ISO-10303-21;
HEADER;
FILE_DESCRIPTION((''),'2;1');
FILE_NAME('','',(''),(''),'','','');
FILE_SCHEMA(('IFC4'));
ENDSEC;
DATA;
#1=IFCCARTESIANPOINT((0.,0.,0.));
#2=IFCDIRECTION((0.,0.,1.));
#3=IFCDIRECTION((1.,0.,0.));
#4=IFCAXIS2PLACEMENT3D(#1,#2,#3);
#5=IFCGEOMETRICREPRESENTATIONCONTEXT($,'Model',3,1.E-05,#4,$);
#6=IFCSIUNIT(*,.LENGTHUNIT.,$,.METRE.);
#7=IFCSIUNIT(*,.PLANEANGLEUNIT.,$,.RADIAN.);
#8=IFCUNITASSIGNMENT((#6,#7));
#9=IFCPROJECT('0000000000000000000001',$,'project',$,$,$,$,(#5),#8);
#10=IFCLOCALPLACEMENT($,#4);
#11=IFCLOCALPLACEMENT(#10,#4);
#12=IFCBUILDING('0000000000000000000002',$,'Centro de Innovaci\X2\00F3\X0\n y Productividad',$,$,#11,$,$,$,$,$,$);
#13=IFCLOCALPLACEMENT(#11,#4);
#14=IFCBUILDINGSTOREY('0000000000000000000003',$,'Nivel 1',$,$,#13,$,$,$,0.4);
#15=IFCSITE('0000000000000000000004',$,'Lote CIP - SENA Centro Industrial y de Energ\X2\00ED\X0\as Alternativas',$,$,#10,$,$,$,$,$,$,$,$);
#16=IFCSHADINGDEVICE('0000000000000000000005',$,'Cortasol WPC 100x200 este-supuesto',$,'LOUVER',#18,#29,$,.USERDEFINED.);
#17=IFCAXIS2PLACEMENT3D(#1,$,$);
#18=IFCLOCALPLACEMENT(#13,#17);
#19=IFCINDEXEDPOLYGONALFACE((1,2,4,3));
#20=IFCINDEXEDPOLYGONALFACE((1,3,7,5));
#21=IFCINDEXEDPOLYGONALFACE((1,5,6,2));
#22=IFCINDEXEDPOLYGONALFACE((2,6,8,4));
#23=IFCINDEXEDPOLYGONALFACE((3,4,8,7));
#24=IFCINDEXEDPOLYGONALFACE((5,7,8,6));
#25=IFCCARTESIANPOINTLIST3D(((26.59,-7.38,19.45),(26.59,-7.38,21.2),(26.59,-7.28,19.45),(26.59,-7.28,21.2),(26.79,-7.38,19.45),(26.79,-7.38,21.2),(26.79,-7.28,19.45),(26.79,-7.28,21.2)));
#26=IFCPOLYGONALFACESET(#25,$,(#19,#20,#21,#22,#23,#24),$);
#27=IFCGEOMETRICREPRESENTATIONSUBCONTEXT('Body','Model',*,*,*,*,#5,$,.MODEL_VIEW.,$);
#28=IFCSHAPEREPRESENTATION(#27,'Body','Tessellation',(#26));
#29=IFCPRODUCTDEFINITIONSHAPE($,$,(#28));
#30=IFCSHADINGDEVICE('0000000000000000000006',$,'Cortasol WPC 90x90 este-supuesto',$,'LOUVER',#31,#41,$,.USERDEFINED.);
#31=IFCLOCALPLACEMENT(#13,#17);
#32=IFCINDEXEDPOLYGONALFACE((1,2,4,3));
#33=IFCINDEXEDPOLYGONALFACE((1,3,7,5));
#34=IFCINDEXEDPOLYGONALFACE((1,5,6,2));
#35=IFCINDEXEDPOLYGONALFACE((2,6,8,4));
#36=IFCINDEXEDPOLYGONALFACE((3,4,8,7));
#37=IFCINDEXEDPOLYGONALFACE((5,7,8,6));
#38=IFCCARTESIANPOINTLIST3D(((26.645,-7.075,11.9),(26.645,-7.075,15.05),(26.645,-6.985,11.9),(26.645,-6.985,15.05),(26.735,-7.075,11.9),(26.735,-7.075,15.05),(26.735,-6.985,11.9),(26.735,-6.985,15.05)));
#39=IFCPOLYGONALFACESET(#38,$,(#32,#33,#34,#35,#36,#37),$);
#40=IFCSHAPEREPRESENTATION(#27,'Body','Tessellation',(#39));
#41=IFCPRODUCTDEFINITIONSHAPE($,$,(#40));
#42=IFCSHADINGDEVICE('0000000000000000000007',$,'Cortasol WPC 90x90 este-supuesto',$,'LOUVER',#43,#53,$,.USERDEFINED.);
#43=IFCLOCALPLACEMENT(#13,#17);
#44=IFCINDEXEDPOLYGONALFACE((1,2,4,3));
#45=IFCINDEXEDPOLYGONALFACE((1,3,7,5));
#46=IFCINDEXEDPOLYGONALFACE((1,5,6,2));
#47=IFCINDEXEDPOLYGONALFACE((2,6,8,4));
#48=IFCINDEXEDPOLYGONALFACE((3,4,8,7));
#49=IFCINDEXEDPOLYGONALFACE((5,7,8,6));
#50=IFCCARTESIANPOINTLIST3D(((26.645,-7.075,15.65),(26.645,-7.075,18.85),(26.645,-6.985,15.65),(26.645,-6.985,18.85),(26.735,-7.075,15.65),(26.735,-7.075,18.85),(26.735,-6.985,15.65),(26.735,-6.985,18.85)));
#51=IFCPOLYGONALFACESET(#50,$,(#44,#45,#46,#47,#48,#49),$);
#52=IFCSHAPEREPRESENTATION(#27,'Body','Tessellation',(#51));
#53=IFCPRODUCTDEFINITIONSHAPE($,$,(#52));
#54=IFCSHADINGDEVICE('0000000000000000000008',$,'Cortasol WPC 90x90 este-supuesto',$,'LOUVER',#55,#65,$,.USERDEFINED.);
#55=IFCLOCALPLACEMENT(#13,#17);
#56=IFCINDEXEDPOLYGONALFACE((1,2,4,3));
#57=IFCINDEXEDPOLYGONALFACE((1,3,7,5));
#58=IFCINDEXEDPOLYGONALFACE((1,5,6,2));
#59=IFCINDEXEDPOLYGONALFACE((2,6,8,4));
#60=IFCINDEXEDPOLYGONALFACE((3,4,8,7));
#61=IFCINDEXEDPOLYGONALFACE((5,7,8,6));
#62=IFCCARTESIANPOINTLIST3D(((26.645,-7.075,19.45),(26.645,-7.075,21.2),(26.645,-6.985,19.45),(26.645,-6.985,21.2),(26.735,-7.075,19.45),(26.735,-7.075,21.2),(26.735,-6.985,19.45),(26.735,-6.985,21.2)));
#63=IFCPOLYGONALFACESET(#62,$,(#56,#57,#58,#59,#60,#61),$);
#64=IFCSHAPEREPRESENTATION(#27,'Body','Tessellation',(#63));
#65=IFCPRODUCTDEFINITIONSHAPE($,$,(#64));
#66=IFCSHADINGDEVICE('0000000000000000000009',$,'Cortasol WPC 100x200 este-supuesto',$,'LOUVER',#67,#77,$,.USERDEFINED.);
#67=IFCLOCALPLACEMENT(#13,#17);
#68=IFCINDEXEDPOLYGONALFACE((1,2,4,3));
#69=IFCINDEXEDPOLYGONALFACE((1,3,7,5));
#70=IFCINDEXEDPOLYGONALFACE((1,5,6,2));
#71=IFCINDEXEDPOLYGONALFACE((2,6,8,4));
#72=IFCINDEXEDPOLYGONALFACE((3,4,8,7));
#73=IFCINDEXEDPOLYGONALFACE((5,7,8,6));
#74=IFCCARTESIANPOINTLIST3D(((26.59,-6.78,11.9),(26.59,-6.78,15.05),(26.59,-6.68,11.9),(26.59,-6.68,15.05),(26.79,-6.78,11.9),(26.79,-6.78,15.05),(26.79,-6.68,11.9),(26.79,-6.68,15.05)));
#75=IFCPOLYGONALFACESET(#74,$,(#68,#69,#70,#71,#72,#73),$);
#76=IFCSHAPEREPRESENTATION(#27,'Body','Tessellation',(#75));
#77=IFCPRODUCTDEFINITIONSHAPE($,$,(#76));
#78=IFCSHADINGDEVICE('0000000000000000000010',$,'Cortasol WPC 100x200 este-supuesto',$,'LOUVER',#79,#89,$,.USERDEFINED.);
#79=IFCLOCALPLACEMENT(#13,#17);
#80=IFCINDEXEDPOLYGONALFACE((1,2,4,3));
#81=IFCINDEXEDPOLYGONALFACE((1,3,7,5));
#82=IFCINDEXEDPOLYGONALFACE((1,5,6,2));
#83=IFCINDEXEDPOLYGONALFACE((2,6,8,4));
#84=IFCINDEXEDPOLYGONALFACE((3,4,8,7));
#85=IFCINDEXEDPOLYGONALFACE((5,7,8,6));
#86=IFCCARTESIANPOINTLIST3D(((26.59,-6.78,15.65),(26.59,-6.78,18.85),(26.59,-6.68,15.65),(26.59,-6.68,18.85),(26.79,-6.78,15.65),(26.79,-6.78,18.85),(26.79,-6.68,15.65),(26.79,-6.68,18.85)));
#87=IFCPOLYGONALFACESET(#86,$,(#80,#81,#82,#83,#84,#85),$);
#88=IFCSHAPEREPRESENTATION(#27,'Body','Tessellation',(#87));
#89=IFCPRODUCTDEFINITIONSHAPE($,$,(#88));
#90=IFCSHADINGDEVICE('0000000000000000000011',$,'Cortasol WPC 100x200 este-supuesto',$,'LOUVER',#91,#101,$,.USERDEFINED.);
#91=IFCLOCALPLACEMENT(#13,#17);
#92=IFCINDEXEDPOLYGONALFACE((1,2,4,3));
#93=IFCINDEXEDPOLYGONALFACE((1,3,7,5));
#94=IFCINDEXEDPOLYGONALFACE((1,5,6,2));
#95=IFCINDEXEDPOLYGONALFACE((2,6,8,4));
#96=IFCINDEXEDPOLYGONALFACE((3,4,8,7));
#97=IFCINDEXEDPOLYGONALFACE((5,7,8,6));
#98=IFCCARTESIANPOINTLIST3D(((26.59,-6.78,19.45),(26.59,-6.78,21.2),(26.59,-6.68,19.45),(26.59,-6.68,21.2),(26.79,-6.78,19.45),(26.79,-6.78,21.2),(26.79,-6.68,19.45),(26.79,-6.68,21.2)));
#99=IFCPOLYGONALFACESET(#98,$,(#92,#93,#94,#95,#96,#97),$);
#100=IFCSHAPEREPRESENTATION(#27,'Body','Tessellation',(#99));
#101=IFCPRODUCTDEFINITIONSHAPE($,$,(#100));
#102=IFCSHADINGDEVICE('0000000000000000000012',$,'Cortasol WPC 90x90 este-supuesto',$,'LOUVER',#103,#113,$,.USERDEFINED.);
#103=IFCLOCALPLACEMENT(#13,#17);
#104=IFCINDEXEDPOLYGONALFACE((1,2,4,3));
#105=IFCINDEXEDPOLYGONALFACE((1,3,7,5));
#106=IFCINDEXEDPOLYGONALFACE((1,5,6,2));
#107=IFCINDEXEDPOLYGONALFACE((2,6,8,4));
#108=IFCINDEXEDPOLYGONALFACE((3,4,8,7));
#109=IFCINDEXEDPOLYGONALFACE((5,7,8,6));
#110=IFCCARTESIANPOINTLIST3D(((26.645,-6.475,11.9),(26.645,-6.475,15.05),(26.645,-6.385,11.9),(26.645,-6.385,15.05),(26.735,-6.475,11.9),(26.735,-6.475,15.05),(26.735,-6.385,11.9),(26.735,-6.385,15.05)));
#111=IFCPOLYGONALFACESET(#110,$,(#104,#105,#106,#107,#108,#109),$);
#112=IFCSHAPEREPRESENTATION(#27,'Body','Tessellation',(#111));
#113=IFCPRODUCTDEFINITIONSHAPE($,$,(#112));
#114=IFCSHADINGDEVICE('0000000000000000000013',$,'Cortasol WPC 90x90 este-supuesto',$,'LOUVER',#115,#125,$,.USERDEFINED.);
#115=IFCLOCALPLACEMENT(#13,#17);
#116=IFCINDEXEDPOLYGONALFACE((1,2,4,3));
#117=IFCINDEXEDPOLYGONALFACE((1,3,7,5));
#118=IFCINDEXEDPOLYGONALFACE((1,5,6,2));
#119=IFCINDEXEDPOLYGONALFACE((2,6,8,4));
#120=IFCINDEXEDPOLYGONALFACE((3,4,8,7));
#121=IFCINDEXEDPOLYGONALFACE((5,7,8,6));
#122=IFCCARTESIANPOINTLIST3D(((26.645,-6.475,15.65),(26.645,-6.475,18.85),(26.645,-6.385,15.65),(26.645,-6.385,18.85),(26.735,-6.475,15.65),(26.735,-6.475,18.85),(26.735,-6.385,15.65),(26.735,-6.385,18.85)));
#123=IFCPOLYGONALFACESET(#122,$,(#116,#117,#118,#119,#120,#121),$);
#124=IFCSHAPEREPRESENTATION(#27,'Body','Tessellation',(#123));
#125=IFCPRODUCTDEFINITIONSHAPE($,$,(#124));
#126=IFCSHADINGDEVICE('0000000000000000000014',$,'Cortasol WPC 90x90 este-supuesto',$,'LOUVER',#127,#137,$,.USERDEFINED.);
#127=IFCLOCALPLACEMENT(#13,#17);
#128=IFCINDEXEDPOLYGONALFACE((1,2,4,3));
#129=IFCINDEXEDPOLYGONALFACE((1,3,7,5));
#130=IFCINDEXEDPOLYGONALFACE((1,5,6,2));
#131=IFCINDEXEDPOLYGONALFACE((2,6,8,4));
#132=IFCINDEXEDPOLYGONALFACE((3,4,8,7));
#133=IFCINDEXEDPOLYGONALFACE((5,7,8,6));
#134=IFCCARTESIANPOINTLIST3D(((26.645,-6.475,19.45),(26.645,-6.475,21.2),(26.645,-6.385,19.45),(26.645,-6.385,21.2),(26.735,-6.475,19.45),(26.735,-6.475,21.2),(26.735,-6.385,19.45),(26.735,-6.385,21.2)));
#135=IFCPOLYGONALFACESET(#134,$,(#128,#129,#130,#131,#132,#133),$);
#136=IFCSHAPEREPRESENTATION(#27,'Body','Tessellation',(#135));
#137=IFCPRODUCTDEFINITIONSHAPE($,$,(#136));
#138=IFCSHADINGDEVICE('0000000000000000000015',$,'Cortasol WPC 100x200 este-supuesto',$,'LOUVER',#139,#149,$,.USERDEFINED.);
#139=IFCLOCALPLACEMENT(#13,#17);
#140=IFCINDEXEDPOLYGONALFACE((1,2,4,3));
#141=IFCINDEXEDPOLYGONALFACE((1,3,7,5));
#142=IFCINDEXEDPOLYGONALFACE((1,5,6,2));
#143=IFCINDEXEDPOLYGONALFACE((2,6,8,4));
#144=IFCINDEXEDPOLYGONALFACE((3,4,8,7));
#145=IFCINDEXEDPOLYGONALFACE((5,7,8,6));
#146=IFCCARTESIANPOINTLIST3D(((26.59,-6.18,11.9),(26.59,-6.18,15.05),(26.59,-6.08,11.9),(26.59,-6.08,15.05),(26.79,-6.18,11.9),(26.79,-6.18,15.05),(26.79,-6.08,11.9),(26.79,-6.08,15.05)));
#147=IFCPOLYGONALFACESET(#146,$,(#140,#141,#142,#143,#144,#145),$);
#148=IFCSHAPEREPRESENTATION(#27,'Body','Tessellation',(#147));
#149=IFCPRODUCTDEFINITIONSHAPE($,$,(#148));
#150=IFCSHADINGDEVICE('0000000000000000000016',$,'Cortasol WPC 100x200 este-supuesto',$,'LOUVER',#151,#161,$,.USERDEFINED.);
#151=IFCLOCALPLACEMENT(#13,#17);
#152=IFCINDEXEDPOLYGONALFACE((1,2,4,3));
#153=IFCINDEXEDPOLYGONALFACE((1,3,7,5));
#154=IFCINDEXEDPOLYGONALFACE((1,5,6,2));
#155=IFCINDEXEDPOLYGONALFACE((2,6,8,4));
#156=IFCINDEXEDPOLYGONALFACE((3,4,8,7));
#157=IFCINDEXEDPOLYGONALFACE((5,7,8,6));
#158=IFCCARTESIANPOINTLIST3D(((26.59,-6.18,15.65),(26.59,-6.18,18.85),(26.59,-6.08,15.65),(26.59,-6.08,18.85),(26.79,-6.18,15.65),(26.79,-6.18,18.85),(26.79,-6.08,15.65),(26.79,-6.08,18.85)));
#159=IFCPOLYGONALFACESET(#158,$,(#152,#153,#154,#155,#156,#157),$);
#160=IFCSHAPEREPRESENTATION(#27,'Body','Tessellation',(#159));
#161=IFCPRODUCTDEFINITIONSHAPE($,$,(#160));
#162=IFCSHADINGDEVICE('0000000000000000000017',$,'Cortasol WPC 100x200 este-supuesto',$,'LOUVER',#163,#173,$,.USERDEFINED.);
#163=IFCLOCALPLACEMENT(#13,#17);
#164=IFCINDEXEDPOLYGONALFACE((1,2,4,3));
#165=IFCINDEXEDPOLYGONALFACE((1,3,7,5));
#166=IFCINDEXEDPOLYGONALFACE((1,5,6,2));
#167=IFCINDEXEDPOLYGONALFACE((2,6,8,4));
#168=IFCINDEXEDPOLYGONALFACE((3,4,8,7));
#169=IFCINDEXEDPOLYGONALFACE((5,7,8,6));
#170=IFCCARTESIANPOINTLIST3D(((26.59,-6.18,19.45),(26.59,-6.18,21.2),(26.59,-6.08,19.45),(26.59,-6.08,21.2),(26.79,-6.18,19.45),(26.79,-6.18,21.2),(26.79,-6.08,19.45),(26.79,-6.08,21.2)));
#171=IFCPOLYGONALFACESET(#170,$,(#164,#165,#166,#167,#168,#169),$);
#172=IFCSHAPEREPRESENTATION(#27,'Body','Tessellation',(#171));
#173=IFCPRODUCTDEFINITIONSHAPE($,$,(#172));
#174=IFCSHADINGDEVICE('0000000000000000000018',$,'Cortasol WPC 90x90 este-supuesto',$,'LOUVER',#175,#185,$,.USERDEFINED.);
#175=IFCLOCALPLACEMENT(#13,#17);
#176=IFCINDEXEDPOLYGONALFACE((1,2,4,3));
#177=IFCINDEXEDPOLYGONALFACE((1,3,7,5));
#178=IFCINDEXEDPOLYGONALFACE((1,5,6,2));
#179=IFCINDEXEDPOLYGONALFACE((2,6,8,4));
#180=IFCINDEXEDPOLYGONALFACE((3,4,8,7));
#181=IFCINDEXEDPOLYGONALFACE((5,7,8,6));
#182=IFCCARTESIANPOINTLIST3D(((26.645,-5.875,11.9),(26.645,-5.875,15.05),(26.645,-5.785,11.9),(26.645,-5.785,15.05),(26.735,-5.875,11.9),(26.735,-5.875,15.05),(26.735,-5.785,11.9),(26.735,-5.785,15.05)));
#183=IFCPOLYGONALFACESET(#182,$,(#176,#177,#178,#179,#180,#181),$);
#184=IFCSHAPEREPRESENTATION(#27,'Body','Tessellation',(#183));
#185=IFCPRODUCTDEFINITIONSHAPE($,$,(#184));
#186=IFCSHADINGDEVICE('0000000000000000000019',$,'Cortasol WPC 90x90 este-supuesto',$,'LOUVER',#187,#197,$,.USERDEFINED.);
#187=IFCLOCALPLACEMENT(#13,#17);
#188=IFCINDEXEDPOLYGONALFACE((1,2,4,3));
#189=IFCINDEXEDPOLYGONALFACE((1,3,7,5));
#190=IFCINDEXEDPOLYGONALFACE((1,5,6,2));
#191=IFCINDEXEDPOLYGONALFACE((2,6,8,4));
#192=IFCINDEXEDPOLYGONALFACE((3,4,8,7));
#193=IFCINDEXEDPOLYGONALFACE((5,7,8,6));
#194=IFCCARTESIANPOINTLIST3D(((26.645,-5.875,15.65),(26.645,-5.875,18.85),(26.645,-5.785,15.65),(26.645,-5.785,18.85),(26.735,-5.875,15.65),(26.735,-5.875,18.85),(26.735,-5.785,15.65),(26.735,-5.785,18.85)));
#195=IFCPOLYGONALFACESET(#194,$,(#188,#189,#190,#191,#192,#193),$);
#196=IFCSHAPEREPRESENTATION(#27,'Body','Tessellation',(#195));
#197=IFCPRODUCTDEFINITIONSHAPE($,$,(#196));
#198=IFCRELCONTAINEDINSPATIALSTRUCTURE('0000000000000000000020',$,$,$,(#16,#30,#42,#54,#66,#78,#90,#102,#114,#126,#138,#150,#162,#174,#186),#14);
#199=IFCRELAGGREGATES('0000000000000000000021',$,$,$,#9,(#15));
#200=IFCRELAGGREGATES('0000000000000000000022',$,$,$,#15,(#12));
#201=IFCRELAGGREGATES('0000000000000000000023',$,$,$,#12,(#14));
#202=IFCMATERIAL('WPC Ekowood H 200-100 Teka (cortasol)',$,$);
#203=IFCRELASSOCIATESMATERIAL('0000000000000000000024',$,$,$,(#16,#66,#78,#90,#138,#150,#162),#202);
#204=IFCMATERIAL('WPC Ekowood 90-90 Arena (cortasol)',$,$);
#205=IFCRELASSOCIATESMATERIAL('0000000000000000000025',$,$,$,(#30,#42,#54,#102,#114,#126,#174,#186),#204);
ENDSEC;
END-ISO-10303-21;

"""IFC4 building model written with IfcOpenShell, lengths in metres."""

from ifc_helpers import new_model, si_unit, frame, origin_with_axes, place, context, subcontext, project, spatial, polyline, outline, extrude, material, element, save


model = new_model("IFC4")

# Units and contexts
model_context = context("Model", 3, precision=1e-05, world=origin_with_axes())
body_context = subcontext(model_context, "Body", "Model", "MODEL_VIEW")
ifc_project = project(units=[si_unit("LENGTHUNIT", "METRE"), si_unit("PLANEANGLEUNIT", "RADIAN")], contexts=[model_context])

# Site, building, storey
site_placement = place(None, origin_with_axes())
site = spatial("IfcSite", under=ifc_project, at=site_placement, Name="Lote CIP - SENA Centro Industrial y de Energías Alternativas")
building_placement = place(site_placement, origin_with_axes())
building = spatial("IfcBuilding", under=site, at=building_placement, Name="Centro de Innovación y Productividad")
storey_placement = place(building_placement, origin_with_axes())
storey = spatial("IfcBuildingStorey", under=building, at=storey_placement, Name="Nivel 1", Elevation=0.4)

# Shading devices
ifc_material_1 = material(Name="WPC Ekowood H 200-100 Teka (cortasol)")
shading_device_1_placement = place(storey_placement, origin_with_axes())
element("IfcShadingDevice", 1, at=shading_device_1_placement, inside=storey, material=ifc_material_1, Name="Cortasol WPC 100x200 este-supuesto", ObjectType="LOUVER", PredefinedType="USERDEFINED", context=body_context, shape_type="SweptSolid", body=[
    extrude(outline(polyline([(26.79, -7.38), (26.59, -7.38), (26.59, -7.28), (26.79, -7.28), (26.79, -7.38)])), frame((0.0, 0.0, 19.45)), (0.0, 0.0, 1.0), 1.75),
])
ifc_material_2 = material(Name="WPC Ekowood 90-90 Arena (cortasol)")
shading_device_2_placement = place(storey_placement, origin_with_axes())
element("IfcShadingDevice", 2, at=shading_device_2_placement, inside=storey, material=ifc_material_2, Name="Cortasol WPC 90x90 este-supuesto", ObjectType="LOUVER", PredefinedType="USERDEFINED", context=body_context, shape_type="SweptSolid", body=[
    extrude(outline(polyline([(26.735, -7.075), (26.645, -7.075), (26.645, -6.985), (26.735, -6.985), (26.735, -7.075)])), frame((0.0, 0.0, 11.9)), (0.0, 0.0, 1.0), 3.15),
])
shading_device_3_placement = place(storey_placement, origin_with_axes())
element("IfcShadingDevice", 3, at=shading_device_3_placement, inside=storey, material=ifc_material_2, Name="Cortasol WPC 90x90 este-supuesto", ObjectType="LOUVER", PredefinedType="USERDEFINED", context=body_context, shape_type="SweptSolid", body=[
    extrude(outline(polyline([(26.735, -7.075), (26.645, -7.075), (26.645, -6.985), (26.735, -6.985), (26.735, -7.075)])), frame((0.0, 0.0, 15.65)), (0.0, 0.0, 1.0), 3.2),
])
shading_device_4_placement = place(storey_placement, origin_with_axes())
element("IfcShadingDevice", 4, at=shading_device_4_placement, inside=storey, material=ifc_material_2, Name="Cortasol WPC 90x90 este-supuesto", ObjectType="LOUVER", PredefinedType="USERDEFINED", context=body_context, shape_type="SweptSolid", body=[
    extrude(outline(polyline([(26.735, -7.075), (26.645, -7.075), (26.645, -6.985), (26.735, -6.985), (26.735, -7.075)])), frame((0.0, 0.0, 19.45)), (0.0, 0.0, 1.0), 1.75),
])
shading_device_5_placement = place(storey_placement, origin_with_axes())
element("IfcShadingDevice", 5, at=shading_device_5_placement, inside=storey, material=ifc_material_1, Name="Cortasol WPC 100x200 este-supuesto", ObjectType="LOUVER", PredefinedType="USERDEFINED", context=body_context, shape_type="SweptSolid", body=[
    extrude(outline(polyline([(26.79, -6.78), (26.59, -6.78), (26.59, -6.68), (26.79, -6.68), (26.79, -6.78)])), frame((0.0, 0.0, 11.9)), (0.0, 0.0, 1.0), 3.15),
])
shading_device_6_placement = place(storey_placement, origin_with_axes())
element("IfcShadingDevice", 6, at=shading_device_6_placement, inside=storey, material=ifc_material_1, Name="Cortasol WPC 100x200 este-supuesto", ObjectType="LOUVER", PredefinedType="USERDEFINED", context=body_context, shape_type="SweptSolid", body=[
    extrude(outline(polyline([(26.79, -6.78), (26.59, -6.78), (26.59, -6.68), (26.79, -6.68), (26.79, -6.78)])), frame((0.0, 0.0, 15.65)), (0.0, 0.0, 1.0), 3.2),
])
shading_device_7_placement = place(storey_placement, origin_with_axes())
element("IfcShadingDevice", 7, at=shading_device_7_placement, inside=storey, material=ifc_material_1, Name="Cortasol WPC 100x200 este-supuesto", ObjectType="LOUVER", PredefinedType="USERDEFINED", context=body_context, shape_type="SweptSolid", body=[
    extrude(outline(polyline([(26.79, -6.78), (26.59, -6.78), (26.59, -6.68), (26.79, -6.68), (26.79, -6.78)])), frame((0.0, 0.0, 19.45)), (0.0, 0.0, 1.0), 1.75),
])
shading_device_8_placement = place(storey_placement, origin_with_axes())
element("IfcShadingDevice", 8, at=shading_device_8_placement, inside=storey, material=ifc_material_2, Name="Cortasol WPC 90x90 este-supuesto", ObjectType="LOUVER", PredefinedType="USERDEFINED", context=body_context, shape_type="SweptSolid", body=[
    extrude(outline(polyline([(26.735, -6.475), (26.645, -6.475), (26.645, -6.385), (26.735, -6.385), (26.735, -6.475)])), frame((0.0, 0.0, 11.9)), (0.0, 0.0, 1.0), 3.15),
])
shading_device_9_placement = place(storey_placement, origin_with_axes())
element("IfcShadingDevice", 9, at=shading_device_9_placement, inside=storey, material=ifc_material_2, Name="Cortasol WPC 90x90 este-supuesto", ObjectType="LOUVER", PredefinedType="USERDEFINED", context=body_context, shape_type="SweptSolid", body=[
    extrude(outline(polyline([(26.735, -6.475), (26.645, -6.475), (26.645, -6.385), (26.735, -6.385), (26.735, -6.475)])), frame((0.0, 0.0, 15.65)), (0.0, 0.0, 1.0), 3.2),
])
shading_device_10_placement = place(storey_placement, origin_with_axes())
element("IfcShadingDevice", 10, at=shading_device_10_placement, inside=storey, material=ifc_material_2, Name="Cortasol WPC 90x90 este-supuesto", ObjectType="LOUVER", PredefinedType="USERDEFINED", context=body_context, shape_type="SweptSolid", body=[
    extrude(outline(polyline([(26.735, -6.475), (26.645, -6.475), (26.645, -6.385), (26.735, -6.385), (26.735, -6.475)])), frame((0.0, 0.0, 19.45)), (0.0, 0.0, 1.0), 1.75),
])
shading_device_11_placement = place(storey_placement, origin_with_axes())
element("IfcShadingDevice", 11, at=shading_device_11_placement, inside=storey, material=ifc_material_1, Name="Cortasol WPC 100x200 este-supuesto", ObjectType="LOUVER", PredefinedType="USERDEFINED", context=body_context, shape_type="SweptSolid", body=[
    extrude(outline(polyline([(26.79, -6.18), (26.59, -6.18), (26.59, -6.08), (26.79, -6.08), (26.79, -6.18)])), frame((0.0, 0.0, 11.9)), (0.0, 0.0, 1.0), 3.15),
])
shading_device_12_placement = place(storey_placement, origin_with_axes())
element("IfcShadingDevice", 12, at=shading_device_12_placement, inside=storey, material=ifc_material_1, Name="Cortasol WPC 100x200 este-supuesto", ObjectType="LOUVER", PredefinedType="USERDEFINED", context=body_context, shape_type="SweptSolid", body=[
    extrude(outline(polyline([(26.79, -6.18), (26.59, -6.18), (26.59, -6.08), (26.79, -6.08), (26.79, -6.18)])), frame((0.0, 0.0, 15.65)), (0.0, 0.0, 1.0), 3.2),
])
shading_device_13_placement = place(storey_placement, origin_with_axes())
element("IfcShadingDevice", 13, at=shading_device_13_placement, inside=storey, material=ifc_material_1, Name="Cortasol WPC 100x200 este-supuesto", ObjectType="LOUVER", PredefinedType="USERDEFINED", context=body_context, shape_type="SweptSolid", body=[
    extrude(outline(polyline([(26.79, -6.18), (26.59, -6.18), (26.59, -6.08), (26.79, -6.08), (26.79, -6.18)])), frame((0.0, 0.0, 19.45)), (0.0, 0.0, 1.0), 1.75),
])
shading_device_14_placement = place(storey_placement, origin_with_axes())
element("IfcShadingDevice", 14, at=shading_device_14_placement, inside=storey, material=ifc_material_2, Name="Cortasol WPC 90x90 este-supuesto", ObjectType="LOUVER", PredefinedType="USERDEFINED", context=body_context, shape_type="SweptSolid", body=[
    extrude(outline(polyline([(26.735, -5.875), (26.645, -5.875), (26.645, -5.785), (26.735, -5.785), (26.735, -5.875)])), frame((0.0, 0.0, 11.9)), (0.0, 0.0, 1.0), 3.15),
])
shading_device_15_placement = place(storey_placement, origin_with_axes())
element("IfcShadingDevice", 15, at=shading_device_15_placement, inside=storey, material=ifc_material_2, Name="Cortasol WPC 90x90 este-supuesto", ObjectType="LOUVER", PredefinedType="USERDEFINED", context=body_context, shape_type="SweptSolid", body=[
    extrude(outline(polyline([(26.735, -5.875), (26.645, -5.875), (26.645, -5.785), (26.735, -5.785), (26.735, -5.875)])), frame((0.0, 0.0, 15.65)), (0.0, 0.0, 1.0), 3.2),
])

save(model, "model.ifc")
